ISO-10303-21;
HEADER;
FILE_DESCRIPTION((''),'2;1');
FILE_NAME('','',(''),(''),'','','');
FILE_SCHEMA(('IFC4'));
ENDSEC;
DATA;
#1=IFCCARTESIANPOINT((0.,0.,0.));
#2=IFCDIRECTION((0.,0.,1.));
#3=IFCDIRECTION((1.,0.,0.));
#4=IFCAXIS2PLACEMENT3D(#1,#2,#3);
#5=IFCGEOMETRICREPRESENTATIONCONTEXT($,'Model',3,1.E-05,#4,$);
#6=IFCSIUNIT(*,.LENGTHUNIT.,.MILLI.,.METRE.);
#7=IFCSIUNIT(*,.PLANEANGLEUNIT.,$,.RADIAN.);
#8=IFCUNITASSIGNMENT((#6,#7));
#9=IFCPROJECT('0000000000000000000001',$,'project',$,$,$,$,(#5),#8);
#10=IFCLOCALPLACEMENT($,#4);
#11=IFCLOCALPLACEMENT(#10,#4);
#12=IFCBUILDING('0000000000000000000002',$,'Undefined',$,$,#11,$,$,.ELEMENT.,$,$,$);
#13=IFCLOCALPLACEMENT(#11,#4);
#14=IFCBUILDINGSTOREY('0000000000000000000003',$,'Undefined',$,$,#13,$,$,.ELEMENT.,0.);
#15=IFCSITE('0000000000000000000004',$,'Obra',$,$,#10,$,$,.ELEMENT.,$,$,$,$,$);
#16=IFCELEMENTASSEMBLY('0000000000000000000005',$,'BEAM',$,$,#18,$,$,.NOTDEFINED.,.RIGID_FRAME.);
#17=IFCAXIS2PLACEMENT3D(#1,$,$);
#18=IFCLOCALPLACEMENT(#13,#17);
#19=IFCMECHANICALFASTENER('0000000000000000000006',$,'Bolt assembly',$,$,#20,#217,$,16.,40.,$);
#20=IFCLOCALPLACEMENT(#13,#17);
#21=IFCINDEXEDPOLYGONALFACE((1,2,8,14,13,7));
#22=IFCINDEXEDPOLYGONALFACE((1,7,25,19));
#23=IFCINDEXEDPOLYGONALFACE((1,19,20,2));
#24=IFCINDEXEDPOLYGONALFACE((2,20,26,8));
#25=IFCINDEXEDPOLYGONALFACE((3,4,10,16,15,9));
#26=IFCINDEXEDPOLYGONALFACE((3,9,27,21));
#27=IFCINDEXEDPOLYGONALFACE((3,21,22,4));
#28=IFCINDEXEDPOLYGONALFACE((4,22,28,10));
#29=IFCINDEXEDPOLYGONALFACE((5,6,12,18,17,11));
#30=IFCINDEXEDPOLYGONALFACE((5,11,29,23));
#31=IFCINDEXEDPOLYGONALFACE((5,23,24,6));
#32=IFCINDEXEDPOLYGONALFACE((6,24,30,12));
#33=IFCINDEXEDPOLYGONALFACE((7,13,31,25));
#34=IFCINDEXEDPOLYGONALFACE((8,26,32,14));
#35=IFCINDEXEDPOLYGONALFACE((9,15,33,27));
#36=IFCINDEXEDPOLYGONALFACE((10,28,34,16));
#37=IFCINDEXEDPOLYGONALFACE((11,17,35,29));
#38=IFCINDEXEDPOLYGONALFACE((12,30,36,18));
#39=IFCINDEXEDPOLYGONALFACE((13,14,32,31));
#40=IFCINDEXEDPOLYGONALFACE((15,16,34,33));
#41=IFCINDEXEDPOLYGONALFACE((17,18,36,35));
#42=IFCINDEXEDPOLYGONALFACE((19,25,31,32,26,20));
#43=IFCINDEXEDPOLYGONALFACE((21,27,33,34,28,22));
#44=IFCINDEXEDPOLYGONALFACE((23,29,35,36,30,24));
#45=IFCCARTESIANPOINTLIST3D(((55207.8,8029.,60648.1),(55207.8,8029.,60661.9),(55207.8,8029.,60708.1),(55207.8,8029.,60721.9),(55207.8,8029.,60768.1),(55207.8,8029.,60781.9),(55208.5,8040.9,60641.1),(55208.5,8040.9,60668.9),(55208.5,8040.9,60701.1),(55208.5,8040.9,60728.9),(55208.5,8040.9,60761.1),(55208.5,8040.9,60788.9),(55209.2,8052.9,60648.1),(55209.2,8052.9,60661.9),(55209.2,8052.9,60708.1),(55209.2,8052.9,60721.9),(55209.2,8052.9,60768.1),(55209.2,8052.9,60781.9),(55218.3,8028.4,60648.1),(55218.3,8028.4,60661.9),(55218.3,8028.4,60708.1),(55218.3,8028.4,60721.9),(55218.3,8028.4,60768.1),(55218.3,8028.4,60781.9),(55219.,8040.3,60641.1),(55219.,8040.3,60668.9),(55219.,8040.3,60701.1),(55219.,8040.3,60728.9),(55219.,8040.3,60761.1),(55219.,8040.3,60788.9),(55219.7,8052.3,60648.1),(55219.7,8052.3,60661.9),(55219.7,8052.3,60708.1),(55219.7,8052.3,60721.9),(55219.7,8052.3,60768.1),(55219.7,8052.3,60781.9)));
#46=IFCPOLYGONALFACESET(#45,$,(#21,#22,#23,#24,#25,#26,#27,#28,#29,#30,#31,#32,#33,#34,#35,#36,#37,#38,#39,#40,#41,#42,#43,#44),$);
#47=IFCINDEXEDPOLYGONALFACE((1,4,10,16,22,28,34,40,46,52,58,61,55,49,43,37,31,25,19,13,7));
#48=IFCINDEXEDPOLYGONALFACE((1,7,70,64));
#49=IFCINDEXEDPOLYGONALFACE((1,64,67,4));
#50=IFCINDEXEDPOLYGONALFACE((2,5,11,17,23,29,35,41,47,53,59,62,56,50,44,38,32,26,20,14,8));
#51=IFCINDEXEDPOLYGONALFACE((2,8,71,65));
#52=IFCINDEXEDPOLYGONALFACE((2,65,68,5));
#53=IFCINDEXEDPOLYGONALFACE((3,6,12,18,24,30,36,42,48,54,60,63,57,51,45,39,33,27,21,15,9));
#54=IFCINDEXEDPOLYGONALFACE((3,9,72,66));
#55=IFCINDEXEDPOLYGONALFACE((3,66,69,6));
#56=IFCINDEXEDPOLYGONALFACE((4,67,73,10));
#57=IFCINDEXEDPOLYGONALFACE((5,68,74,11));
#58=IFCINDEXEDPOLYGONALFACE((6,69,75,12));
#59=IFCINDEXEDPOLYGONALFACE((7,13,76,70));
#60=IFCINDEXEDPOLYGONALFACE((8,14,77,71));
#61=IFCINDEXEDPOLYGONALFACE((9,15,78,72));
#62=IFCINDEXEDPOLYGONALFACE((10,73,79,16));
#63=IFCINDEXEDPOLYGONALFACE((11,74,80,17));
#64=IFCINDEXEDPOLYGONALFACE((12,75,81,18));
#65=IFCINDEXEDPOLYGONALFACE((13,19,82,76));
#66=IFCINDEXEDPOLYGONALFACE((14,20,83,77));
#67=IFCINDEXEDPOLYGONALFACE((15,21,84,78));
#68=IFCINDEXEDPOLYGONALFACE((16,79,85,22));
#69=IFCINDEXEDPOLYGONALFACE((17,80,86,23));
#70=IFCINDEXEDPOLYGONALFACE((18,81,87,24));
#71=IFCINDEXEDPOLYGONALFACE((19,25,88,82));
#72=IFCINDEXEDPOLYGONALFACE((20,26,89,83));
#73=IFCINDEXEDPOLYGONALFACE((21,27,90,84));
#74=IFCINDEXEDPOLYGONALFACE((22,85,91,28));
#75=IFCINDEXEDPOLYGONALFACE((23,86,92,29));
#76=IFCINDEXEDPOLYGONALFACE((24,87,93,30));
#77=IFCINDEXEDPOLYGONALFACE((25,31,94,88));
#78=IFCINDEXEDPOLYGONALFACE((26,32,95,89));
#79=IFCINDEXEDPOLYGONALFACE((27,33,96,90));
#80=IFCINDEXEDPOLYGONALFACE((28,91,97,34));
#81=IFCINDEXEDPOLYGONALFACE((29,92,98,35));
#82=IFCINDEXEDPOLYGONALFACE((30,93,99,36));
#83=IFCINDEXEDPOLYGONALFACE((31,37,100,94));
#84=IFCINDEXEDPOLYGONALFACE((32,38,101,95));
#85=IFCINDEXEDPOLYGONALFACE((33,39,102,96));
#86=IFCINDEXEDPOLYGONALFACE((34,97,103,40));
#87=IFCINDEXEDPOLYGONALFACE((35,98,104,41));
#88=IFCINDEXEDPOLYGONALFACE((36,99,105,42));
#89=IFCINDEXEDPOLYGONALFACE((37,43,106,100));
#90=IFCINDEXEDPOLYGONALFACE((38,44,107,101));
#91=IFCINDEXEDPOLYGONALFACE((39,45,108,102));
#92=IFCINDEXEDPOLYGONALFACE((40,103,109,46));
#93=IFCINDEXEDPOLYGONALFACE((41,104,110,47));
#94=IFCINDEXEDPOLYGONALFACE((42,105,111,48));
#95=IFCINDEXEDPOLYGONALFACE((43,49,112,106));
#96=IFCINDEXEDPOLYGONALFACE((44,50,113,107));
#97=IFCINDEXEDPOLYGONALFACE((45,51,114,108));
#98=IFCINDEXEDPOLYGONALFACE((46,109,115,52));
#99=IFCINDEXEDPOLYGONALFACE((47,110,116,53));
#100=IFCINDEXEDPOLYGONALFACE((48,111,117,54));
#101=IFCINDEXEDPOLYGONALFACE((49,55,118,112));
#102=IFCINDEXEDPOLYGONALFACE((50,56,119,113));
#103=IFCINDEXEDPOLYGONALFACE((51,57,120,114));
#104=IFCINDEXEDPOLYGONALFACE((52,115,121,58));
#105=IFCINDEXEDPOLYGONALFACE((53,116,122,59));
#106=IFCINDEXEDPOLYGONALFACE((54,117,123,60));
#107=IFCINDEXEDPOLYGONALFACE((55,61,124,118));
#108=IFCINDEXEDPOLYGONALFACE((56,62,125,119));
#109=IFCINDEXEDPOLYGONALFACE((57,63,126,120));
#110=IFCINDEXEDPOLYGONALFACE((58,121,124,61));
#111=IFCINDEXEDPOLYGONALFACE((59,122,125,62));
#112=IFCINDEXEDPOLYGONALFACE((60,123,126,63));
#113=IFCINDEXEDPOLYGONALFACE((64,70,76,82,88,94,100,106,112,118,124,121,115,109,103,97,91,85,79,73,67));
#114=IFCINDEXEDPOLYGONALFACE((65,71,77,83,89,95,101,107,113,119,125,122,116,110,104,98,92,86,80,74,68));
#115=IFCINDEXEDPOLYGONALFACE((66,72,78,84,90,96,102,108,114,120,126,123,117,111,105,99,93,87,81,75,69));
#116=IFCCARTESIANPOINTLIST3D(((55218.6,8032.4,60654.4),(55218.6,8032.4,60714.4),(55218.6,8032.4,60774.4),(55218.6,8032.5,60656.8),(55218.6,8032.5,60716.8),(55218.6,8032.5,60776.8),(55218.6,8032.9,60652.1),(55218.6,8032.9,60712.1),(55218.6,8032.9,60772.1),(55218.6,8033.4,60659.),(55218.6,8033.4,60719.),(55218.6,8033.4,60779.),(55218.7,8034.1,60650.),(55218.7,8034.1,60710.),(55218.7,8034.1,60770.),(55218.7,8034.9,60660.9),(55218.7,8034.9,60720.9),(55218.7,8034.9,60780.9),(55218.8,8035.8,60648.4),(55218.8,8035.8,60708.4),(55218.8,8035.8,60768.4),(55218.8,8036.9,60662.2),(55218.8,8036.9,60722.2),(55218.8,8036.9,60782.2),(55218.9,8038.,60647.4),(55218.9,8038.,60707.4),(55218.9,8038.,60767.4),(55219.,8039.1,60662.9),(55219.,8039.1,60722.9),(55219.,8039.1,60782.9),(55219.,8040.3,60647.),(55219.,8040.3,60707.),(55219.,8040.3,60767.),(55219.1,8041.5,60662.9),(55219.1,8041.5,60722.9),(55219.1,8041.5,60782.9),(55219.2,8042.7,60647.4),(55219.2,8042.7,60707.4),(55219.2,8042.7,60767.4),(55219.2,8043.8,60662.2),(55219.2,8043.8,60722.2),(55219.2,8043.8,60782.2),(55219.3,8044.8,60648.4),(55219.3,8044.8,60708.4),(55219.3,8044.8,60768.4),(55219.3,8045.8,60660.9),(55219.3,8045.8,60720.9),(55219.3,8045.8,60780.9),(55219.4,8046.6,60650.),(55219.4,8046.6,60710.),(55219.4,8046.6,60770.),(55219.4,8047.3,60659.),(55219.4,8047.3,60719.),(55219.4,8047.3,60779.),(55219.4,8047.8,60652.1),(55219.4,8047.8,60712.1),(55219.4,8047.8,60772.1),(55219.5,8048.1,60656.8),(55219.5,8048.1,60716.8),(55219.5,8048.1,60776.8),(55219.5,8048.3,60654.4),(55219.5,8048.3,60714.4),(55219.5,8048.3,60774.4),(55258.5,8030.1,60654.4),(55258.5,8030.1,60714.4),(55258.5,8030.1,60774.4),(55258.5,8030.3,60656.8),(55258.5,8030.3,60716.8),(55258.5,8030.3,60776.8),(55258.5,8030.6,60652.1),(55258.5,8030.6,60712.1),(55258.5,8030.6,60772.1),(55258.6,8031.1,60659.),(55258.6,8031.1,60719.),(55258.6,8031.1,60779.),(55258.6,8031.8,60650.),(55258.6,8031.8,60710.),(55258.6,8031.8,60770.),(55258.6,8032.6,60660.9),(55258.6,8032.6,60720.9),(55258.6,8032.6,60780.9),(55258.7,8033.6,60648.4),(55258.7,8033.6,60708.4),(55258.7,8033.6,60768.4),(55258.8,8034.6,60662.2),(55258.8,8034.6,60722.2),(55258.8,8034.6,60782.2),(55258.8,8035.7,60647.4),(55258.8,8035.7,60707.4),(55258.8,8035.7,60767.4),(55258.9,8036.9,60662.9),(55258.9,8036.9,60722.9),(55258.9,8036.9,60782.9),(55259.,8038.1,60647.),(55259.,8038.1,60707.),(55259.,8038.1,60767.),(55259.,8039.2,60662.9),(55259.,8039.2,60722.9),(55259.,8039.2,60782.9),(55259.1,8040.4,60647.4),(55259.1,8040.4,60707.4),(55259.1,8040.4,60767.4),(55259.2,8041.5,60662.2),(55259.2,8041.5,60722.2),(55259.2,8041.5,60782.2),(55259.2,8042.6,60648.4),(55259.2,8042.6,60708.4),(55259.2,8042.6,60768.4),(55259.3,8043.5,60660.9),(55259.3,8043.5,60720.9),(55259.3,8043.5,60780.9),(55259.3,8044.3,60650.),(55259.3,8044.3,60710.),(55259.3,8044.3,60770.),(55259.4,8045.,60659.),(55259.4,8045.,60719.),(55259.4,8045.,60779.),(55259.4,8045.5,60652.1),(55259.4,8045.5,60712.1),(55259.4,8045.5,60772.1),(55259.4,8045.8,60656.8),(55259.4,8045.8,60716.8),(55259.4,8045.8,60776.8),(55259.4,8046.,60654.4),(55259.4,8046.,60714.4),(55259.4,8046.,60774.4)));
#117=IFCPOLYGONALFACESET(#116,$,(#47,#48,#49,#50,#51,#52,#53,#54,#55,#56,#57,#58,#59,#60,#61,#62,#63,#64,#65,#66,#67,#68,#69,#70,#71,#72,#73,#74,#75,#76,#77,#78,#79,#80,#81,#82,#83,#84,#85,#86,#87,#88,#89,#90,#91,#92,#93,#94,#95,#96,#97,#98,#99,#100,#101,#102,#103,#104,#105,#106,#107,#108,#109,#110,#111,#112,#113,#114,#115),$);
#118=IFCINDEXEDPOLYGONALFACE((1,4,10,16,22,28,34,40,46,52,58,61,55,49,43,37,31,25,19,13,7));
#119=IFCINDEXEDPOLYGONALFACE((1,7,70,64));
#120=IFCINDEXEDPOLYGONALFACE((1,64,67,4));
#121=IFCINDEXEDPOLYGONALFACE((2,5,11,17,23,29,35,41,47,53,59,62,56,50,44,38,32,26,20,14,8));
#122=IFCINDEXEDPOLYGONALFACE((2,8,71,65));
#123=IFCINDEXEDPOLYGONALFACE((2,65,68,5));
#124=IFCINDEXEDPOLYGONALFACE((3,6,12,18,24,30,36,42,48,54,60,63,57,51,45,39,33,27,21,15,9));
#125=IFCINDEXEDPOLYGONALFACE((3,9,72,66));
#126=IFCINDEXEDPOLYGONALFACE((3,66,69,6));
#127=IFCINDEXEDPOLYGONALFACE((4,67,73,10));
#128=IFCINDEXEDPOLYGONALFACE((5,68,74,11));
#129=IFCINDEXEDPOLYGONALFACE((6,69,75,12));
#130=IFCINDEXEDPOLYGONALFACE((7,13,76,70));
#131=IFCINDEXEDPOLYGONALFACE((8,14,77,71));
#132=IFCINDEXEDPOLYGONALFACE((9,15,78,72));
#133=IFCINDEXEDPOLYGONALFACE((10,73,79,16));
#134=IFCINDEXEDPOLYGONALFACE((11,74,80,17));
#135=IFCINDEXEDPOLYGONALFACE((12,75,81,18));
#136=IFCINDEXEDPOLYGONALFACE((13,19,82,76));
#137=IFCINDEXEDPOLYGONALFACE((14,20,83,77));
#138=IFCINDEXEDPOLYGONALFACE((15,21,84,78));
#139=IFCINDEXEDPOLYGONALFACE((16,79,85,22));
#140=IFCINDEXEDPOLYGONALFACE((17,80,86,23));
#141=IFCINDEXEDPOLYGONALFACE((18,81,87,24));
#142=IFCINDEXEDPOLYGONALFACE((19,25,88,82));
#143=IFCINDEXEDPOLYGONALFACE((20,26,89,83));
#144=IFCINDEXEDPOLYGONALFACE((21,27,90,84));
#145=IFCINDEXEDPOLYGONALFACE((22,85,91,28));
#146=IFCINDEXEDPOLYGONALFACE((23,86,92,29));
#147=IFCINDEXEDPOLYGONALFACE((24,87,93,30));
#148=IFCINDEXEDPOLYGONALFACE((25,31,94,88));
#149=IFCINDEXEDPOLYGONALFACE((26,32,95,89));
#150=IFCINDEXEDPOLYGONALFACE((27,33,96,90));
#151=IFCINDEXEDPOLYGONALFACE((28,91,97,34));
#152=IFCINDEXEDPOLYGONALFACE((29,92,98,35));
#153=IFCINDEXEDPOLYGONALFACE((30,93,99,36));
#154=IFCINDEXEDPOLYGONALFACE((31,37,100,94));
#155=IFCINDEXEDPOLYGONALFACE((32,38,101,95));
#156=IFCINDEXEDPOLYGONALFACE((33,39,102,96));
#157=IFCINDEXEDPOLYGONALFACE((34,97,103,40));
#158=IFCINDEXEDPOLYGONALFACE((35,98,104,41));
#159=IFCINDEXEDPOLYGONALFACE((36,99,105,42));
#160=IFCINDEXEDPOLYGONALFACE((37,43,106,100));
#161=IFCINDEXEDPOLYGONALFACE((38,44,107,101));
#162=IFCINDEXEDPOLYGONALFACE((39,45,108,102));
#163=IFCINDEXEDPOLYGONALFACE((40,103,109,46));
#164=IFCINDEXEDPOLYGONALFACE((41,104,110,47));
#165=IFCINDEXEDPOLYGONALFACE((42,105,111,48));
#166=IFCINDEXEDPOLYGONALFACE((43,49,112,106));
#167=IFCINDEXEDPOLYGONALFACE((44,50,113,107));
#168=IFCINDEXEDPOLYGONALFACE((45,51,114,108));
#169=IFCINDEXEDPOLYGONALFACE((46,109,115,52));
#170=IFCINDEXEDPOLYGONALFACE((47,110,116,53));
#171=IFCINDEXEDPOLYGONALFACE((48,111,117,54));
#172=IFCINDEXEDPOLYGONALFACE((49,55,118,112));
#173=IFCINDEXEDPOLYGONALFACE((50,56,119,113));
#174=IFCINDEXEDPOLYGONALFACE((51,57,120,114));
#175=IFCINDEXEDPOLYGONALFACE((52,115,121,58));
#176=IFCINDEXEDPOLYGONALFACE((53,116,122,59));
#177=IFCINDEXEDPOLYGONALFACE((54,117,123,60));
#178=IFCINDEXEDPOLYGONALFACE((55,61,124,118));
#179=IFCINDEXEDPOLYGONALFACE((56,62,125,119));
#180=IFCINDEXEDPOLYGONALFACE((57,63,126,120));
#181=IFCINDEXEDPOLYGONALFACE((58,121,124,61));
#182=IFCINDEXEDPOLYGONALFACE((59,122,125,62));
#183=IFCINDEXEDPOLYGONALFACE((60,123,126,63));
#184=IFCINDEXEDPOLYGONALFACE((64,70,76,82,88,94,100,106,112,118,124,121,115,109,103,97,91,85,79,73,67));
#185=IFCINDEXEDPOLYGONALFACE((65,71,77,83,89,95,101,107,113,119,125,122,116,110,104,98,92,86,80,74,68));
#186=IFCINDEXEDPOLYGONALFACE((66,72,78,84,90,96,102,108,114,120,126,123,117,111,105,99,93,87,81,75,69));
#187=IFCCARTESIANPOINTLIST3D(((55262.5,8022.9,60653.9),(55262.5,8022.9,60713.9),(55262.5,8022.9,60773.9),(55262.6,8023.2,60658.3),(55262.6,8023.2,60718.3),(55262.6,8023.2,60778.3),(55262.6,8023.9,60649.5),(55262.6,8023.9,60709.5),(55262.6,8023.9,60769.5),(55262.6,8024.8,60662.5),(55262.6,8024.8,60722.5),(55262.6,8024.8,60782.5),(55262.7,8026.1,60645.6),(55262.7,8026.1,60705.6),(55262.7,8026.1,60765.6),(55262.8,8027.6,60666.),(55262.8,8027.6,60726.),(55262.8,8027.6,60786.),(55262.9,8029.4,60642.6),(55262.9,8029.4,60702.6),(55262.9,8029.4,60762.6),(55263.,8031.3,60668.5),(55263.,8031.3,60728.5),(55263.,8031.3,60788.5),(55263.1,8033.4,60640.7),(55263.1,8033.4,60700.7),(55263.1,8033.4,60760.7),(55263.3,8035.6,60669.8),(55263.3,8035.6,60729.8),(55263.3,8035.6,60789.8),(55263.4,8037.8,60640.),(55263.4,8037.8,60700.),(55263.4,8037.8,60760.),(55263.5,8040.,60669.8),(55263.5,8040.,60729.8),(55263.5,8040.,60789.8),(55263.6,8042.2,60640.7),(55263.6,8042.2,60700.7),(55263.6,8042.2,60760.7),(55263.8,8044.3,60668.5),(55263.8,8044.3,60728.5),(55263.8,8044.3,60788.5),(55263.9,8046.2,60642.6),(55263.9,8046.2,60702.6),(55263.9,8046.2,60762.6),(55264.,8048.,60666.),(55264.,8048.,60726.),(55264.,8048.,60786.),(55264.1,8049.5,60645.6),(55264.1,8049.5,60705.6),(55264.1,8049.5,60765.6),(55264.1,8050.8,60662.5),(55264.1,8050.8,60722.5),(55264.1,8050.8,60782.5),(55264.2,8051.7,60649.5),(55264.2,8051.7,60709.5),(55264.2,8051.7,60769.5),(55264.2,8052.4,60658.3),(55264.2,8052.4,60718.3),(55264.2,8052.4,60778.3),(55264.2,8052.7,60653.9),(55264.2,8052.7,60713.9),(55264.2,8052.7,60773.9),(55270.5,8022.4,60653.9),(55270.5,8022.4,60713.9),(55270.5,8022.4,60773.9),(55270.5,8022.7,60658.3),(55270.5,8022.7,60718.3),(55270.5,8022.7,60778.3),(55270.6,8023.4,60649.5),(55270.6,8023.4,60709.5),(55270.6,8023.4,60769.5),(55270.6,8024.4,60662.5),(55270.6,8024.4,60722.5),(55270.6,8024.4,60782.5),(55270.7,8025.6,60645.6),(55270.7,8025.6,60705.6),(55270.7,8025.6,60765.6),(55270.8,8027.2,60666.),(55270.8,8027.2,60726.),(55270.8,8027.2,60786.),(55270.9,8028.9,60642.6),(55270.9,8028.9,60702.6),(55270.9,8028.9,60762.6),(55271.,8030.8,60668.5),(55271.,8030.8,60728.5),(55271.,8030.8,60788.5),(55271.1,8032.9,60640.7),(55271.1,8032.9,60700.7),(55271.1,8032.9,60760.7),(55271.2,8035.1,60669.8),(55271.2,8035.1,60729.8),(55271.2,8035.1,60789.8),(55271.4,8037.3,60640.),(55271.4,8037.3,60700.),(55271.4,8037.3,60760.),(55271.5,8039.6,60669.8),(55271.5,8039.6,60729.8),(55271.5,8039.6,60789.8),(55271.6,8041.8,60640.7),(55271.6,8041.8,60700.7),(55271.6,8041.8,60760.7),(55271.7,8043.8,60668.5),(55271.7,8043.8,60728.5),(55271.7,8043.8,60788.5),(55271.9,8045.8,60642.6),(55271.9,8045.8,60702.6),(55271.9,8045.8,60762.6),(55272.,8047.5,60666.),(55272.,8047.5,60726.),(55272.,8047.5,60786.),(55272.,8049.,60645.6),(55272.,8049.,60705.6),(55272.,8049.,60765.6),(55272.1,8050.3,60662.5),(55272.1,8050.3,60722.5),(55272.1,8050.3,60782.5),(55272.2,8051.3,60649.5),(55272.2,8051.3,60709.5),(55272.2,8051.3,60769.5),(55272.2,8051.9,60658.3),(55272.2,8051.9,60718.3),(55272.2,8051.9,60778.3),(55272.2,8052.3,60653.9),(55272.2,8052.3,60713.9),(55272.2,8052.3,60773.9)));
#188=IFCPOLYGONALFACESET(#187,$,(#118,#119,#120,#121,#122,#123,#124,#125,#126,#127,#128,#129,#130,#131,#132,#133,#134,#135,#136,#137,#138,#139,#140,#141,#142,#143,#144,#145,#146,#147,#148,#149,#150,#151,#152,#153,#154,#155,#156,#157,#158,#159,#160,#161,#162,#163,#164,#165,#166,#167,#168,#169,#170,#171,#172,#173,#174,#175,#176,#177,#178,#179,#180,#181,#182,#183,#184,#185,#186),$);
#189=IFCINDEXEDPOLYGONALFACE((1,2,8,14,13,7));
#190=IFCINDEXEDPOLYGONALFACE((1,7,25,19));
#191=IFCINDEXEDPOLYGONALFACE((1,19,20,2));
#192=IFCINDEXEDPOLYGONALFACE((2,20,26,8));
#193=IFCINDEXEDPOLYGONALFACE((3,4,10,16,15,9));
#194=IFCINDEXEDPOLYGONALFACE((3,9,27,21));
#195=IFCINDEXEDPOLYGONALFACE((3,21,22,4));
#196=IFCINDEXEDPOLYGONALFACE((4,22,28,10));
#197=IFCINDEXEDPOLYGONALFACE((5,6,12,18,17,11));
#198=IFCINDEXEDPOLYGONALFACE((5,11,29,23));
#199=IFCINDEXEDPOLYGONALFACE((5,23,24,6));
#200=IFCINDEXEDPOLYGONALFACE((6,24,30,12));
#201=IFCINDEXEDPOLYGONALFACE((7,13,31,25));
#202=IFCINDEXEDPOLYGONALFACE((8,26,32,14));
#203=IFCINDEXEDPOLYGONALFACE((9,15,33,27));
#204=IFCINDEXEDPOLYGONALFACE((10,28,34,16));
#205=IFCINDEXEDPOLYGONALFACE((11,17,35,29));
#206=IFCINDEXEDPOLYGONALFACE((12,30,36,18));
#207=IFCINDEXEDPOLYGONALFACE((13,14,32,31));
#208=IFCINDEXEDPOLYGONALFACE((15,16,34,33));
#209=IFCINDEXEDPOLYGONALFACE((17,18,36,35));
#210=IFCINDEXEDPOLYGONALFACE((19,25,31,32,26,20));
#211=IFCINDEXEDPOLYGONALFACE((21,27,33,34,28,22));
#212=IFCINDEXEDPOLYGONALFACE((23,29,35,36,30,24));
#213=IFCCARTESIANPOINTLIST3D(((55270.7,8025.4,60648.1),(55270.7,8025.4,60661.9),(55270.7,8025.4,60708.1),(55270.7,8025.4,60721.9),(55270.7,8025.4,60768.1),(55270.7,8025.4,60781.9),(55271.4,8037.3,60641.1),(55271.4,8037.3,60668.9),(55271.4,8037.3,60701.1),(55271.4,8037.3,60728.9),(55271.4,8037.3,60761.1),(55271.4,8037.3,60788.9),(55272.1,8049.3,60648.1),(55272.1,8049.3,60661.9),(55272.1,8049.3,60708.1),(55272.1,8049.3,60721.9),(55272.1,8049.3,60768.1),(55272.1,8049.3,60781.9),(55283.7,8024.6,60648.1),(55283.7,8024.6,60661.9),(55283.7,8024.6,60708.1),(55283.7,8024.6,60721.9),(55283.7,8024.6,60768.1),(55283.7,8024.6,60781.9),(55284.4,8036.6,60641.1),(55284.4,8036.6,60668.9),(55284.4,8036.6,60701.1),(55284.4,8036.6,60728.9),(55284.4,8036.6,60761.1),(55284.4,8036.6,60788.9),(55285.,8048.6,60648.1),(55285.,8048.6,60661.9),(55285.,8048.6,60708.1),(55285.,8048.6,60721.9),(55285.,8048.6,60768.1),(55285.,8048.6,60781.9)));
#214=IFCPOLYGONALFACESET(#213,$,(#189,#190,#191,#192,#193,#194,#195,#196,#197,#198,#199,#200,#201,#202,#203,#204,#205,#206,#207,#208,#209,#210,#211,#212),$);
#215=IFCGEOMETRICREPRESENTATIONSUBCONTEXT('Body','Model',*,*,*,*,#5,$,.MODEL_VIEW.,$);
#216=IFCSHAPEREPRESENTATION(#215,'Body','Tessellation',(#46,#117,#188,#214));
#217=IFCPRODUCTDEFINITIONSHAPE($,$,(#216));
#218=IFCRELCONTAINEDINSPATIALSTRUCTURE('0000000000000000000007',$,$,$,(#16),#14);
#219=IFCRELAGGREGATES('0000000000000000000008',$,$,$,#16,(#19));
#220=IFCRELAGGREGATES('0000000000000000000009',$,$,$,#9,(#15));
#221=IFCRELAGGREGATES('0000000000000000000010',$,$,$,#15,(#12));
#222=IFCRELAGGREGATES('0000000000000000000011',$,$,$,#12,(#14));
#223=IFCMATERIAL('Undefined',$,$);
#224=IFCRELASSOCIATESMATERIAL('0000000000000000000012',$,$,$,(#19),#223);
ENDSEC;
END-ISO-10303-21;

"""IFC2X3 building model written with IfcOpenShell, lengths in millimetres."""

from ifc_helpers import new_model, si_unit, frame, origin_with_axes, origin_2d_with_axis, place, context, subcontext, project, spatial, polyline, circle, outline, extrude, source, transform, mapped, material, element, aggregate, save


model = new_model("IFC2X3")

# Units and contexts
model_context = context("Model", 3, precision=1e-05, world=origin_with_axes())
body_context = subcontext(model_context, "Body", "Model", "MODEL_VIEW")
ifc_project = project(units=[si_unit("LENGTHUNIT", "METRE", prefix="MILLI"), si_unit("PLANEANGLEUNIT", "RADIAN")], contexts=[model_context])

# Site, building, storey
site_placement = place(None, origin_with_axes())
site = spatial("IfcSite", under=ifc_project, at=site_placement, Name="Obra", CompositionType="ELEMENT")
building_placement = place(site_placement, origin_with_axes())
building = spatial("IfcBuilding", under=site, at=building_placement, Name="Undefined", CompositionType="ELEMENT")
storey_placement = place(building_placement, origin_with_axes())
storey = spatial("IfcBuildingStorey", under=building, at=storey_placement, Name="Undefined", CompositionType="ELEMENT", Elevation=0.0)

# Element assembly, mechanical fastener
ifc_material_1 = material(Name="Undefined")
shared_shape_1 = source(origin_with_axes(), body_context, "Body", "SweptSolid", [
    extrude(outline(polyline([(13.9, 0.0), (6.9, 12.0), (-6.9, 12.0), (-13.9, 0.0), (-6.9, -12.0), (6.9, -12.0), (13.9, 0.0)])), frame((0.0, -19.7, 0.0), z_axis=(0.0, 1.0, 0.0), x_axis=(1.0, 0.0, 0.0)), (0.0, 0.0, 1.0), 10.6),
    extrude(circle(Radius=8.0, at=origin_2d_with_axis()), frame((0.0, -9.1, 0.0), z_axis=(0.0, 1.0, 0.0), x_axis=(1.0, 0.0, 0.0)), (0.0, 0.0, 1.0), 40.0),
    extrude(circle(Radius=15.0, at=origin_2d_with_axis()), frame((0.0, 35.3, 0.0), z_axis=(0.0, 1.0, 0.0), x_axis=(1.0, 0.0, 0.0)), (0.0, 0.0, 1.0), 8.0),
    extrude(outline(polyline([(13.9, 0.0), (6.9, 12.0), (-6.9, 12.0), (-13.9, 0.0), (-6.9, -12.0), (6.9, -12.0), (13.9, 0.0)])), frame((0.0, 43.3, 0.0), z_axis=(0.0, 1.0, 0.0), x_axis=(1.0, 0.0, 0.0)), (0.0, 0.0, 1.0), 13.0),
])
assembly_1_placement = place(storey_placement, origin_with_axes())
assembly_1 = element("IfcElementAssembly", 1, at=assembly_1_placement, inside=storey, Name="BEAM", AssemblyPlace="NOTDEFINED", PredefinedType="RIGID_FRAME")
mechanical_fastener_1_placement = place(assembly_1_placement, frame((55231.0, 8089.7, 60835.0), z_axis=(-0.05711, -0.998368, 0.0), x_axis=(0.0, 0.0, -1.0)))
mechanical_fastener_1 = element("IfcMechanicalFastener", 2, at=mechanical_fastener_1_placement, material=ifc_material_1, Name="Bolt assembly", NominalDiameter=16.0, NominalLength=40.0, context=body_context, shape_type="MappedRepresentation", body=[
    mapped(shared_shape_1, transform((60.0, 0.0, 50.0))),
    mapped(shared_shape_1, transform((120.0, 0.0, 50.0))),
    mapped(shared_shape_1, transform((180.0, 0.0, 50.0))),
])

aggregate(assembly_1, [mechanical_fastener_1])

save(model, "model.ifc")
